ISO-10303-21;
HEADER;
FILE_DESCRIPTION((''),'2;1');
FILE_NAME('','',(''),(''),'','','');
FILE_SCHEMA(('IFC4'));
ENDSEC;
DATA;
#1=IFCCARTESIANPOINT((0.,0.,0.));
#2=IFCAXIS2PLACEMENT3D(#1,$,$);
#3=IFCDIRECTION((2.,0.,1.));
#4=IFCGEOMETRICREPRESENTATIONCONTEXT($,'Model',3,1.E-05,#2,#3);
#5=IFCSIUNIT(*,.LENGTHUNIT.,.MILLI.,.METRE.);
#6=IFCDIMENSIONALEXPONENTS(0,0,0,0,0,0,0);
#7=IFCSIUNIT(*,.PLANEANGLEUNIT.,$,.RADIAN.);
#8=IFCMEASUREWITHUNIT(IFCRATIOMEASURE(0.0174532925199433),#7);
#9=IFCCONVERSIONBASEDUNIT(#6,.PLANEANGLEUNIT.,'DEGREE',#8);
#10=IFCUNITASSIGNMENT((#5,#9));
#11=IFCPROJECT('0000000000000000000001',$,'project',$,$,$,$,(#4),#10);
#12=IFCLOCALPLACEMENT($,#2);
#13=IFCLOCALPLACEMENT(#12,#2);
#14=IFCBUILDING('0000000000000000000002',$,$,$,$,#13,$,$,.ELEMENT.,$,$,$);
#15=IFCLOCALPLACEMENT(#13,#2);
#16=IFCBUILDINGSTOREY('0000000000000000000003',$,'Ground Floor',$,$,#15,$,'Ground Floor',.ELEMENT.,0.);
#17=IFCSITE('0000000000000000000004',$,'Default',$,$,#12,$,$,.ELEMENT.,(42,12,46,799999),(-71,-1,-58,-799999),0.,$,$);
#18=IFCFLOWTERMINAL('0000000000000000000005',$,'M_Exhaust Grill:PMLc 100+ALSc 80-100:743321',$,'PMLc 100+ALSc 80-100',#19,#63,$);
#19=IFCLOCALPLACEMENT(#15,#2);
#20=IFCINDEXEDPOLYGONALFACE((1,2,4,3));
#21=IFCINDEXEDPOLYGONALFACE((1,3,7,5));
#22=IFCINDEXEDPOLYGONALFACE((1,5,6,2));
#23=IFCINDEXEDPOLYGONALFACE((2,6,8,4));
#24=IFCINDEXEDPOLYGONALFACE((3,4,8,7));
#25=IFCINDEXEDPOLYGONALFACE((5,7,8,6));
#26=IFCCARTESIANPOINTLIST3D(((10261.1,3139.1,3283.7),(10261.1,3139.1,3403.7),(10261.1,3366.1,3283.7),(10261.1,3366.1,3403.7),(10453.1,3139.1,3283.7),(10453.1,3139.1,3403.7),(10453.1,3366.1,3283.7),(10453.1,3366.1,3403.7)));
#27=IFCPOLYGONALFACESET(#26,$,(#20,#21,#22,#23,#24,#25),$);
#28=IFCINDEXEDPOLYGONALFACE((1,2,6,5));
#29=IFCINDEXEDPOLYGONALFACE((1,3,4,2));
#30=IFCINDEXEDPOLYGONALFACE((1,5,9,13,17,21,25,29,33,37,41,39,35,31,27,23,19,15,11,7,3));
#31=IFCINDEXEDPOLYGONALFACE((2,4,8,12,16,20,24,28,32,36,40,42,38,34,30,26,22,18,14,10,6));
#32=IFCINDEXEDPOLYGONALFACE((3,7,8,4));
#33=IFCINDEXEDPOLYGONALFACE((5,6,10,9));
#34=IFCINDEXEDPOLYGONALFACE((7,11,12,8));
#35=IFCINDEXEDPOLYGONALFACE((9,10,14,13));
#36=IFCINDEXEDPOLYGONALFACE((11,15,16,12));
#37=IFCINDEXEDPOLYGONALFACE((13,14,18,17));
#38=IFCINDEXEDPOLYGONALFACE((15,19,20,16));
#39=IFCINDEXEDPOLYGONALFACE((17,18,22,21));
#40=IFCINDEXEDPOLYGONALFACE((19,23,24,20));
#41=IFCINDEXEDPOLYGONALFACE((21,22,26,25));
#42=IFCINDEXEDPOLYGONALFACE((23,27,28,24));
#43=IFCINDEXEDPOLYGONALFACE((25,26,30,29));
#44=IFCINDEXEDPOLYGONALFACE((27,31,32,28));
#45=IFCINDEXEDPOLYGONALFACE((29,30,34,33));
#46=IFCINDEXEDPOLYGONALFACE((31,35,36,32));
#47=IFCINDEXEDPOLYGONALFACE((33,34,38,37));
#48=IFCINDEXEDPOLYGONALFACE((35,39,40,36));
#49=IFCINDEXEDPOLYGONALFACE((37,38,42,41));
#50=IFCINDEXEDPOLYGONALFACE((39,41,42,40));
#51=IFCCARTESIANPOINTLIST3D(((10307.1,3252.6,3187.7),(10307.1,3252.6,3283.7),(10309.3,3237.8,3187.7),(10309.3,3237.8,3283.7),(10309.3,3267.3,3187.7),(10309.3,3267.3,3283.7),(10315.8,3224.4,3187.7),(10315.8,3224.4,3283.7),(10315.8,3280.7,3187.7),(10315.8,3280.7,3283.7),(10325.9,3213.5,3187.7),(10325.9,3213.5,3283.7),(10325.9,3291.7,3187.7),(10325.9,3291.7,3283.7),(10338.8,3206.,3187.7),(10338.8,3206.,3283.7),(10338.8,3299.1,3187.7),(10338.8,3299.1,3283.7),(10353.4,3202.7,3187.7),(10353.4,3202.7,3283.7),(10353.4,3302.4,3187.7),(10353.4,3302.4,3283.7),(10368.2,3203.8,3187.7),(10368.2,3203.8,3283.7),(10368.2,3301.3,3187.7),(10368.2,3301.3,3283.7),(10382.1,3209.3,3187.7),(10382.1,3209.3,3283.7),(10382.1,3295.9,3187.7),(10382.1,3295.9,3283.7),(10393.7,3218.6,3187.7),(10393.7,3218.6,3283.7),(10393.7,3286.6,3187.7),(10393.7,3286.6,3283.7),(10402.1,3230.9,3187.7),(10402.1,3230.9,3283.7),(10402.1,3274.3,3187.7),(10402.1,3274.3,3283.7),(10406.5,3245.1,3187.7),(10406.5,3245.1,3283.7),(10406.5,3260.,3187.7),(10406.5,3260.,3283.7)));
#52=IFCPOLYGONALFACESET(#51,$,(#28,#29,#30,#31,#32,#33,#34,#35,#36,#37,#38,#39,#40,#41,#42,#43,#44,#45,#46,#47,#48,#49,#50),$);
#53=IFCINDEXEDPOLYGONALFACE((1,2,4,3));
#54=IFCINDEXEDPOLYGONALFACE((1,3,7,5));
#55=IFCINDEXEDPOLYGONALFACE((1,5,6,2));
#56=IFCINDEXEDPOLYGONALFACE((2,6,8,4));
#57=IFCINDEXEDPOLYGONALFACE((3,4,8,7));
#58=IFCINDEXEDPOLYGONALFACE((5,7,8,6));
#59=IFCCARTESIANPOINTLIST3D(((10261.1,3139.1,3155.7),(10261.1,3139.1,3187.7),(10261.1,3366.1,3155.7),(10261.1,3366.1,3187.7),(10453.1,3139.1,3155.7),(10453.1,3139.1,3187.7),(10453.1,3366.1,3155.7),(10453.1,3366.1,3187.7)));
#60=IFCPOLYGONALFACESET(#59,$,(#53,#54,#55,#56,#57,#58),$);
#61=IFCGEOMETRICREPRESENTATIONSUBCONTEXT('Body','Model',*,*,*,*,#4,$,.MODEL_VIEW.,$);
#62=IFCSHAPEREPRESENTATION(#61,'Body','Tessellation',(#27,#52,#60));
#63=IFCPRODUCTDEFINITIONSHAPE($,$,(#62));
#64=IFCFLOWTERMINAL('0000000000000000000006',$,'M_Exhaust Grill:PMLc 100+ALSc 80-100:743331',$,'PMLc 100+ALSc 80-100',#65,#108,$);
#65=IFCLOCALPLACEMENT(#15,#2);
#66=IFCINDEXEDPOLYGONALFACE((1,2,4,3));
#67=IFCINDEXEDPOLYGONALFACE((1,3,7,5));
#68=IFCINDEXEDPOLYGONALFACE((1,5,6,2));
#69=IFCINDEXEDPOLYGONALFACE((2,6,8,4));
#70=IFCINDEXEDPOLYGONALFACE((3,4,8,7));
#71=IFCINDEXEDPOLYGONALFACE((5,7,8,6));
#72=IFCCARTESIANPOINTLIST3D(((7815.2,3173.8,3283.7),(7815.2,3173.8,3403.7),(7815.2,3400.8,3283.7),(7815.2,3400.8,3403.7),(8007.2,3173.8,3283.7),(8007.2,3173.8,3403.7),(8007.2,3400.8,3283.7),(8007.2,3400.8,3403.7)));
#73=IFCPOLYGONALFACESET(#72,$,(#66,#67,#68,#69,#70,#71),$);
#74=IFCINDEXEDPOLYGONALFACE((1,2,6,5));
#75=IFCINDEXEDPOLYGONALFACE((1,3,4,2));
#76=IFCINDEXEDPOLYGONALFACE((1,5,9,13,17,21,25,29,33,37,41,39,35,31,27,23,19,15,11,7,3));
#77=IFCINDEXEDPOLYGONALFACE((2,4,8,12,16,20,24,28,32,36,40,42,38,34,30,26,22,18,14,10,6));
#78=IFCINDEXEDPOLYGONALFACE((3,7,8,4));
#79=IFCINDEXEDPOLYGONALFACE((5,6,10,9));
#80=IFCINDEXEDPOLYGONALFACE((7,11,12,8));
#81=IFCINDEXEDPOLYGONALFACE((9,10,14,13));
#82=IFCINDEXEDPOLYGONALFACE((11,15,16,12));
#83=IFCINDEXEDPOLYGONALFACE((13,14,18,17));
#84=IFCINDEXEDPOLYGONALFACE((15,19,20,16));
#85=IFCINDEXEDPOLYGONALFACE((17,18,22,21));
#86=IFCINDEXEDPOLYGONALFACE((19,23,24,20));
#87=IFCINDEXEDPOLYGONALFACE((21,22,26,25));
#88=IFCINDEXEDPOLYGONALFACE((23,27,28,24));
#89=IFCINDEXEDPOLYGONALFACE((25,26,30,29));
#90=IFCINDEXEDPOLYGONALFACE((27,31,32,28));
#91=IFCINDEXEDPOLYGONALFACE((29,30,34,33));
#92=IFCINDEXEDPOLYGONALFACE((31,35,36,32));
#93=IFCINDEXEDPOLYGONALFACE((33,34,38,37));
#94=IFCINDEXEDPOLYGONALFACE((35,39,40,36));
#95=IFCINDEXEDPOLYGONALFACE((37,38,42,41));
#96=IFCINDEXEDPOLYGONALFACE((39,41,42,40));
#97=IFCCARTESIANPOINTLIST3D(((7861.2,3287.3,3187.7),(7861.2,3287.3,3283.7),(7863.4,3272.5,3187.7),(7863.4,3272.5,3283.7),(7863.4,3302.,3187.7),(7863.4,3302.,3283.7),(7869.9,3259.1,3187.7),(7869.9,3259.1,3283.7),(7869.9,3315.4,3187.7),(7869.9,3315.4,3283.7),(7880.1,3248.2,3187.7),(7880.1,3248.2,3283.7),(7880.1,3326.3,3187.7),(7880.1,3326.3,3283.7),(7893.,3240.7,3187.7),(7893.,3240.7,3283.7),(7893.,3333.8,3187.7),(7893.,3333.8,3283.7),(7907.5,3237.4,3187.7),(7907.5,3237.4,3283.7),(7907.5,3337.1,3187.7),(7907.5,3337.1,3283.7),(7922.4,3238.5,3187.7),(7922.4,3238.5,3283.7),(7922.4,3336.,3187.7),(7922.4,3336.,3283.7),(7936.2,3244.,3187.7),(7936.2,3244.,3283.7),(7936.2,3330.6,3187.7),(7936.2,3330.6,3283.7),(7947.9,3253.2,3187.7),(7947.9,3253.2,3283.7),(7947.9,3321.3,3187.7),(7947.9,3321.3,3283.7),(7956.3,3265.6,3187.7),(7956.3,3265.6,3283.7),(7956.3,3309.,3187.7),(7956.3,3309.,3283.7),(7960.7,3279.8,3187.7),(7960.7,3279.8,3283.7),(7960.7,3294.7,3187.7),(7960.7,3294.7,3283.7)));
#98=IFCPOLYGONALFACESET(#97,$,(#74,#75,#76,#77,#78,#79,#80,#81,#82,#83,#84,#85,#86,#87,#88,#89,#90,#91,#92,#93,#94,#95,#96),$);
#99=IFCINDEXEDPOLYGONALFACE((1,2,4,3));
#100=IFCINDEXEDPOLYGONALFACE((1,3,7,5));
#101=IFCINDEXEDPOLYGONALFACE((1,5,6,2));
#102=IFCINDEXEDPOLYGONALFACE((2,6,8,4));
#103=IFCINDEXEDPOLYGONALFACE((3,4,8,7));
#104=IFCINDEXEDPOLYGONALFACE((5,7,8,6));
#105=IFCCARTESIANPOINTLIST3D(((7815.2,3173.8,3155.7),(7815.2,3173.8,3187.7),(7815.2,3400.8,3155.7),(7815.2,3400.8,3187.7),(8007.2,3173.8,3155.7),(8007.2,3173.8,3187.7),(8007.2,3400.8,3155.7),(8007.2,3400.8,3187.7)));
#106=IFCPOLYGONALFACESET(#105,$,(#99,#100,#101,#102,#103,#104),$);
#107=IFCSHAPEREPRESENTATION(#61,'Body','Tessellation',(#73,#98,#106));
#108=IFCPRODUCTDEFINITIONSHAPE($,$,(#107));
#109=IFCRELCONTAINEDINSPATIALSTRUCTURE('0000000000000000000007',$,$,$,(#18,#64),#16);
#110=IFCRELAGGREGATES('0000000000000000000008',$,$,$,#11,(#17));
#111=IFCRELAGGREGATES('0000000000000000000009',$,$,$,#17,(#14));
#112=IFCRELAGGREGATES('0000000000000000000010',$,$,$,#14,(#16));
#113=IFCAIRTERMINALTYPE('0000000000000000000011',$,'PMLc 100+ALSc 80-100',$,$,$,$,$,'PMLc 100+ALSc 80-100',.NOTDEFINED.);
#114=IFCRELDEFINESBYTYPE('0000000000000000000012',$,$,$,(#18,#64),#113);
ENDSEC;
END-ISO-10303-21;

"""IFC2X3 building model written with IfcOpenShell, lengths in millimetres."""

from ifc_helpers import new_model, entity, si_unit, converted_unit, direction, frame, frame_2d, origin, origin_2d_with_axis, place, context, subcontext, project, spatial, rectangle, circle, extrude, source, transform, mapped, type_object, type_shapes, element, save


model = new_model("IFC2X3")

# Units and contexts
model_context = context("Model", 3, precision=1e-05, world=origin(), true_north=direction((2.0, 0.0, 1.0)))
body_context = subcontext(model_context, "Body", "Model", "MODEL_VIEW")
ifc_project = project(units=[si_unit("LENGTHUNIT", "METRE", prefix="MILLI"), converted_unit("PLANEANGLEUNIT", "DEGREE", entity("IfcRatioMeasure", 0.0174532925199433), si_unit("PLANEANGLEUNIT", "RADIAN"), dimensions=[0, 0, 0, 0, 0, 0, 0])], contexts=[model_context])

# Site, building, storey
site_placement = place(None, origin())
site = spatial("IfcSite", under=ifc_project, at=site_placement, Name="Default", CompositionType="ELEMENT", RefLatitude=(42, 12, 46, 799999), RefLongitude=(-71, -1, -58, -799999), RefElevation=0.0)
building_placement = place(site_placement, origin())
building = spatial("IfcBuilding", under=site, at=building_placement, CompositionType="ELEMENT")
storey_placement = place(building_placement, origin())
storey = spatial("IfcBuildingStorey", under=building, at=storey_placement, Name="Ground Floor", LongName="Ground Floor", CompositionType="ELEMENT", Elevation=0.0)

# Flow terminals
air_terminal_type_1 = type_object("IfcAirTerminalType", Name="PMLc 100+ALSc 80-100", ElementType="PMLc 100+ALSc 80-100", PredefinedType="NOTDEFINED")
shared_shape_1 = source(origin(), body_context, "Body", "SweptSolid", [
    extrude(rectangle(XDim=227.0, YDim=192.0, at=origin_2d_with_axis()), frame((0.0, 3.8, 128.0), z_axis=(0.0, 0.0, 1.0), x_axis=(0.0, 1.0, 0.0)), (0.0, 0.0, 1.0), 120.0),
    extrude(circle(Radius=50.0, at=frame_2d((0.0, 0.0), x_axis=(1.0, 0.0))), frame((0.0, 3.8, 32.0)), (0.0, 0.0, 1.0), 96.0),
    extrude(rectangle(XDim=227.0, YDim=192.0, at=origin_2d_with_axis()), frame((0.0, 3.8, 0.0), z_axis=(0.0, 0.0, 1.0), x_axis=(0.0, 1.0, 0.0)), (0.0, 0.0, 1.0), 32.0),
])
type_shapes(air_terminal_type_1, [shared_shape_1])
for number, where, z_axis, x_axis, name in (
    (1, (10357.1, 3256.3, 3155.7), (0.0, 0.0, 1.0), (-1.0, 0.0, 0.0), "M_Exhaust Grill:PMLc 100+ALSc 80-100:743321"),
    (2, (7911.2, 3291.0, 3155.7), (0.0, 0.0, 1.0), (-1.0, 0.0, 0.0), "M_Exhaust Grill:PMLc 100+ALSc 80-100:743331"),
):
    element("IfcFlowTerminal", number, at=place(storey_placement, frame(where, z_axis=z_axis, x_axis=x_axis)), inside=storey, type_object=air_terminal_type_1, Name=name, ObjectType="PMLc 100+ALSc 80-100", context=body_context, shape_type="MappedRepresentation", body=[
        mapped(shared_shape_1, transform((0.0, 0.0, 0.0), scale=1.0)),
    ])

save(model, "model.ifc")
